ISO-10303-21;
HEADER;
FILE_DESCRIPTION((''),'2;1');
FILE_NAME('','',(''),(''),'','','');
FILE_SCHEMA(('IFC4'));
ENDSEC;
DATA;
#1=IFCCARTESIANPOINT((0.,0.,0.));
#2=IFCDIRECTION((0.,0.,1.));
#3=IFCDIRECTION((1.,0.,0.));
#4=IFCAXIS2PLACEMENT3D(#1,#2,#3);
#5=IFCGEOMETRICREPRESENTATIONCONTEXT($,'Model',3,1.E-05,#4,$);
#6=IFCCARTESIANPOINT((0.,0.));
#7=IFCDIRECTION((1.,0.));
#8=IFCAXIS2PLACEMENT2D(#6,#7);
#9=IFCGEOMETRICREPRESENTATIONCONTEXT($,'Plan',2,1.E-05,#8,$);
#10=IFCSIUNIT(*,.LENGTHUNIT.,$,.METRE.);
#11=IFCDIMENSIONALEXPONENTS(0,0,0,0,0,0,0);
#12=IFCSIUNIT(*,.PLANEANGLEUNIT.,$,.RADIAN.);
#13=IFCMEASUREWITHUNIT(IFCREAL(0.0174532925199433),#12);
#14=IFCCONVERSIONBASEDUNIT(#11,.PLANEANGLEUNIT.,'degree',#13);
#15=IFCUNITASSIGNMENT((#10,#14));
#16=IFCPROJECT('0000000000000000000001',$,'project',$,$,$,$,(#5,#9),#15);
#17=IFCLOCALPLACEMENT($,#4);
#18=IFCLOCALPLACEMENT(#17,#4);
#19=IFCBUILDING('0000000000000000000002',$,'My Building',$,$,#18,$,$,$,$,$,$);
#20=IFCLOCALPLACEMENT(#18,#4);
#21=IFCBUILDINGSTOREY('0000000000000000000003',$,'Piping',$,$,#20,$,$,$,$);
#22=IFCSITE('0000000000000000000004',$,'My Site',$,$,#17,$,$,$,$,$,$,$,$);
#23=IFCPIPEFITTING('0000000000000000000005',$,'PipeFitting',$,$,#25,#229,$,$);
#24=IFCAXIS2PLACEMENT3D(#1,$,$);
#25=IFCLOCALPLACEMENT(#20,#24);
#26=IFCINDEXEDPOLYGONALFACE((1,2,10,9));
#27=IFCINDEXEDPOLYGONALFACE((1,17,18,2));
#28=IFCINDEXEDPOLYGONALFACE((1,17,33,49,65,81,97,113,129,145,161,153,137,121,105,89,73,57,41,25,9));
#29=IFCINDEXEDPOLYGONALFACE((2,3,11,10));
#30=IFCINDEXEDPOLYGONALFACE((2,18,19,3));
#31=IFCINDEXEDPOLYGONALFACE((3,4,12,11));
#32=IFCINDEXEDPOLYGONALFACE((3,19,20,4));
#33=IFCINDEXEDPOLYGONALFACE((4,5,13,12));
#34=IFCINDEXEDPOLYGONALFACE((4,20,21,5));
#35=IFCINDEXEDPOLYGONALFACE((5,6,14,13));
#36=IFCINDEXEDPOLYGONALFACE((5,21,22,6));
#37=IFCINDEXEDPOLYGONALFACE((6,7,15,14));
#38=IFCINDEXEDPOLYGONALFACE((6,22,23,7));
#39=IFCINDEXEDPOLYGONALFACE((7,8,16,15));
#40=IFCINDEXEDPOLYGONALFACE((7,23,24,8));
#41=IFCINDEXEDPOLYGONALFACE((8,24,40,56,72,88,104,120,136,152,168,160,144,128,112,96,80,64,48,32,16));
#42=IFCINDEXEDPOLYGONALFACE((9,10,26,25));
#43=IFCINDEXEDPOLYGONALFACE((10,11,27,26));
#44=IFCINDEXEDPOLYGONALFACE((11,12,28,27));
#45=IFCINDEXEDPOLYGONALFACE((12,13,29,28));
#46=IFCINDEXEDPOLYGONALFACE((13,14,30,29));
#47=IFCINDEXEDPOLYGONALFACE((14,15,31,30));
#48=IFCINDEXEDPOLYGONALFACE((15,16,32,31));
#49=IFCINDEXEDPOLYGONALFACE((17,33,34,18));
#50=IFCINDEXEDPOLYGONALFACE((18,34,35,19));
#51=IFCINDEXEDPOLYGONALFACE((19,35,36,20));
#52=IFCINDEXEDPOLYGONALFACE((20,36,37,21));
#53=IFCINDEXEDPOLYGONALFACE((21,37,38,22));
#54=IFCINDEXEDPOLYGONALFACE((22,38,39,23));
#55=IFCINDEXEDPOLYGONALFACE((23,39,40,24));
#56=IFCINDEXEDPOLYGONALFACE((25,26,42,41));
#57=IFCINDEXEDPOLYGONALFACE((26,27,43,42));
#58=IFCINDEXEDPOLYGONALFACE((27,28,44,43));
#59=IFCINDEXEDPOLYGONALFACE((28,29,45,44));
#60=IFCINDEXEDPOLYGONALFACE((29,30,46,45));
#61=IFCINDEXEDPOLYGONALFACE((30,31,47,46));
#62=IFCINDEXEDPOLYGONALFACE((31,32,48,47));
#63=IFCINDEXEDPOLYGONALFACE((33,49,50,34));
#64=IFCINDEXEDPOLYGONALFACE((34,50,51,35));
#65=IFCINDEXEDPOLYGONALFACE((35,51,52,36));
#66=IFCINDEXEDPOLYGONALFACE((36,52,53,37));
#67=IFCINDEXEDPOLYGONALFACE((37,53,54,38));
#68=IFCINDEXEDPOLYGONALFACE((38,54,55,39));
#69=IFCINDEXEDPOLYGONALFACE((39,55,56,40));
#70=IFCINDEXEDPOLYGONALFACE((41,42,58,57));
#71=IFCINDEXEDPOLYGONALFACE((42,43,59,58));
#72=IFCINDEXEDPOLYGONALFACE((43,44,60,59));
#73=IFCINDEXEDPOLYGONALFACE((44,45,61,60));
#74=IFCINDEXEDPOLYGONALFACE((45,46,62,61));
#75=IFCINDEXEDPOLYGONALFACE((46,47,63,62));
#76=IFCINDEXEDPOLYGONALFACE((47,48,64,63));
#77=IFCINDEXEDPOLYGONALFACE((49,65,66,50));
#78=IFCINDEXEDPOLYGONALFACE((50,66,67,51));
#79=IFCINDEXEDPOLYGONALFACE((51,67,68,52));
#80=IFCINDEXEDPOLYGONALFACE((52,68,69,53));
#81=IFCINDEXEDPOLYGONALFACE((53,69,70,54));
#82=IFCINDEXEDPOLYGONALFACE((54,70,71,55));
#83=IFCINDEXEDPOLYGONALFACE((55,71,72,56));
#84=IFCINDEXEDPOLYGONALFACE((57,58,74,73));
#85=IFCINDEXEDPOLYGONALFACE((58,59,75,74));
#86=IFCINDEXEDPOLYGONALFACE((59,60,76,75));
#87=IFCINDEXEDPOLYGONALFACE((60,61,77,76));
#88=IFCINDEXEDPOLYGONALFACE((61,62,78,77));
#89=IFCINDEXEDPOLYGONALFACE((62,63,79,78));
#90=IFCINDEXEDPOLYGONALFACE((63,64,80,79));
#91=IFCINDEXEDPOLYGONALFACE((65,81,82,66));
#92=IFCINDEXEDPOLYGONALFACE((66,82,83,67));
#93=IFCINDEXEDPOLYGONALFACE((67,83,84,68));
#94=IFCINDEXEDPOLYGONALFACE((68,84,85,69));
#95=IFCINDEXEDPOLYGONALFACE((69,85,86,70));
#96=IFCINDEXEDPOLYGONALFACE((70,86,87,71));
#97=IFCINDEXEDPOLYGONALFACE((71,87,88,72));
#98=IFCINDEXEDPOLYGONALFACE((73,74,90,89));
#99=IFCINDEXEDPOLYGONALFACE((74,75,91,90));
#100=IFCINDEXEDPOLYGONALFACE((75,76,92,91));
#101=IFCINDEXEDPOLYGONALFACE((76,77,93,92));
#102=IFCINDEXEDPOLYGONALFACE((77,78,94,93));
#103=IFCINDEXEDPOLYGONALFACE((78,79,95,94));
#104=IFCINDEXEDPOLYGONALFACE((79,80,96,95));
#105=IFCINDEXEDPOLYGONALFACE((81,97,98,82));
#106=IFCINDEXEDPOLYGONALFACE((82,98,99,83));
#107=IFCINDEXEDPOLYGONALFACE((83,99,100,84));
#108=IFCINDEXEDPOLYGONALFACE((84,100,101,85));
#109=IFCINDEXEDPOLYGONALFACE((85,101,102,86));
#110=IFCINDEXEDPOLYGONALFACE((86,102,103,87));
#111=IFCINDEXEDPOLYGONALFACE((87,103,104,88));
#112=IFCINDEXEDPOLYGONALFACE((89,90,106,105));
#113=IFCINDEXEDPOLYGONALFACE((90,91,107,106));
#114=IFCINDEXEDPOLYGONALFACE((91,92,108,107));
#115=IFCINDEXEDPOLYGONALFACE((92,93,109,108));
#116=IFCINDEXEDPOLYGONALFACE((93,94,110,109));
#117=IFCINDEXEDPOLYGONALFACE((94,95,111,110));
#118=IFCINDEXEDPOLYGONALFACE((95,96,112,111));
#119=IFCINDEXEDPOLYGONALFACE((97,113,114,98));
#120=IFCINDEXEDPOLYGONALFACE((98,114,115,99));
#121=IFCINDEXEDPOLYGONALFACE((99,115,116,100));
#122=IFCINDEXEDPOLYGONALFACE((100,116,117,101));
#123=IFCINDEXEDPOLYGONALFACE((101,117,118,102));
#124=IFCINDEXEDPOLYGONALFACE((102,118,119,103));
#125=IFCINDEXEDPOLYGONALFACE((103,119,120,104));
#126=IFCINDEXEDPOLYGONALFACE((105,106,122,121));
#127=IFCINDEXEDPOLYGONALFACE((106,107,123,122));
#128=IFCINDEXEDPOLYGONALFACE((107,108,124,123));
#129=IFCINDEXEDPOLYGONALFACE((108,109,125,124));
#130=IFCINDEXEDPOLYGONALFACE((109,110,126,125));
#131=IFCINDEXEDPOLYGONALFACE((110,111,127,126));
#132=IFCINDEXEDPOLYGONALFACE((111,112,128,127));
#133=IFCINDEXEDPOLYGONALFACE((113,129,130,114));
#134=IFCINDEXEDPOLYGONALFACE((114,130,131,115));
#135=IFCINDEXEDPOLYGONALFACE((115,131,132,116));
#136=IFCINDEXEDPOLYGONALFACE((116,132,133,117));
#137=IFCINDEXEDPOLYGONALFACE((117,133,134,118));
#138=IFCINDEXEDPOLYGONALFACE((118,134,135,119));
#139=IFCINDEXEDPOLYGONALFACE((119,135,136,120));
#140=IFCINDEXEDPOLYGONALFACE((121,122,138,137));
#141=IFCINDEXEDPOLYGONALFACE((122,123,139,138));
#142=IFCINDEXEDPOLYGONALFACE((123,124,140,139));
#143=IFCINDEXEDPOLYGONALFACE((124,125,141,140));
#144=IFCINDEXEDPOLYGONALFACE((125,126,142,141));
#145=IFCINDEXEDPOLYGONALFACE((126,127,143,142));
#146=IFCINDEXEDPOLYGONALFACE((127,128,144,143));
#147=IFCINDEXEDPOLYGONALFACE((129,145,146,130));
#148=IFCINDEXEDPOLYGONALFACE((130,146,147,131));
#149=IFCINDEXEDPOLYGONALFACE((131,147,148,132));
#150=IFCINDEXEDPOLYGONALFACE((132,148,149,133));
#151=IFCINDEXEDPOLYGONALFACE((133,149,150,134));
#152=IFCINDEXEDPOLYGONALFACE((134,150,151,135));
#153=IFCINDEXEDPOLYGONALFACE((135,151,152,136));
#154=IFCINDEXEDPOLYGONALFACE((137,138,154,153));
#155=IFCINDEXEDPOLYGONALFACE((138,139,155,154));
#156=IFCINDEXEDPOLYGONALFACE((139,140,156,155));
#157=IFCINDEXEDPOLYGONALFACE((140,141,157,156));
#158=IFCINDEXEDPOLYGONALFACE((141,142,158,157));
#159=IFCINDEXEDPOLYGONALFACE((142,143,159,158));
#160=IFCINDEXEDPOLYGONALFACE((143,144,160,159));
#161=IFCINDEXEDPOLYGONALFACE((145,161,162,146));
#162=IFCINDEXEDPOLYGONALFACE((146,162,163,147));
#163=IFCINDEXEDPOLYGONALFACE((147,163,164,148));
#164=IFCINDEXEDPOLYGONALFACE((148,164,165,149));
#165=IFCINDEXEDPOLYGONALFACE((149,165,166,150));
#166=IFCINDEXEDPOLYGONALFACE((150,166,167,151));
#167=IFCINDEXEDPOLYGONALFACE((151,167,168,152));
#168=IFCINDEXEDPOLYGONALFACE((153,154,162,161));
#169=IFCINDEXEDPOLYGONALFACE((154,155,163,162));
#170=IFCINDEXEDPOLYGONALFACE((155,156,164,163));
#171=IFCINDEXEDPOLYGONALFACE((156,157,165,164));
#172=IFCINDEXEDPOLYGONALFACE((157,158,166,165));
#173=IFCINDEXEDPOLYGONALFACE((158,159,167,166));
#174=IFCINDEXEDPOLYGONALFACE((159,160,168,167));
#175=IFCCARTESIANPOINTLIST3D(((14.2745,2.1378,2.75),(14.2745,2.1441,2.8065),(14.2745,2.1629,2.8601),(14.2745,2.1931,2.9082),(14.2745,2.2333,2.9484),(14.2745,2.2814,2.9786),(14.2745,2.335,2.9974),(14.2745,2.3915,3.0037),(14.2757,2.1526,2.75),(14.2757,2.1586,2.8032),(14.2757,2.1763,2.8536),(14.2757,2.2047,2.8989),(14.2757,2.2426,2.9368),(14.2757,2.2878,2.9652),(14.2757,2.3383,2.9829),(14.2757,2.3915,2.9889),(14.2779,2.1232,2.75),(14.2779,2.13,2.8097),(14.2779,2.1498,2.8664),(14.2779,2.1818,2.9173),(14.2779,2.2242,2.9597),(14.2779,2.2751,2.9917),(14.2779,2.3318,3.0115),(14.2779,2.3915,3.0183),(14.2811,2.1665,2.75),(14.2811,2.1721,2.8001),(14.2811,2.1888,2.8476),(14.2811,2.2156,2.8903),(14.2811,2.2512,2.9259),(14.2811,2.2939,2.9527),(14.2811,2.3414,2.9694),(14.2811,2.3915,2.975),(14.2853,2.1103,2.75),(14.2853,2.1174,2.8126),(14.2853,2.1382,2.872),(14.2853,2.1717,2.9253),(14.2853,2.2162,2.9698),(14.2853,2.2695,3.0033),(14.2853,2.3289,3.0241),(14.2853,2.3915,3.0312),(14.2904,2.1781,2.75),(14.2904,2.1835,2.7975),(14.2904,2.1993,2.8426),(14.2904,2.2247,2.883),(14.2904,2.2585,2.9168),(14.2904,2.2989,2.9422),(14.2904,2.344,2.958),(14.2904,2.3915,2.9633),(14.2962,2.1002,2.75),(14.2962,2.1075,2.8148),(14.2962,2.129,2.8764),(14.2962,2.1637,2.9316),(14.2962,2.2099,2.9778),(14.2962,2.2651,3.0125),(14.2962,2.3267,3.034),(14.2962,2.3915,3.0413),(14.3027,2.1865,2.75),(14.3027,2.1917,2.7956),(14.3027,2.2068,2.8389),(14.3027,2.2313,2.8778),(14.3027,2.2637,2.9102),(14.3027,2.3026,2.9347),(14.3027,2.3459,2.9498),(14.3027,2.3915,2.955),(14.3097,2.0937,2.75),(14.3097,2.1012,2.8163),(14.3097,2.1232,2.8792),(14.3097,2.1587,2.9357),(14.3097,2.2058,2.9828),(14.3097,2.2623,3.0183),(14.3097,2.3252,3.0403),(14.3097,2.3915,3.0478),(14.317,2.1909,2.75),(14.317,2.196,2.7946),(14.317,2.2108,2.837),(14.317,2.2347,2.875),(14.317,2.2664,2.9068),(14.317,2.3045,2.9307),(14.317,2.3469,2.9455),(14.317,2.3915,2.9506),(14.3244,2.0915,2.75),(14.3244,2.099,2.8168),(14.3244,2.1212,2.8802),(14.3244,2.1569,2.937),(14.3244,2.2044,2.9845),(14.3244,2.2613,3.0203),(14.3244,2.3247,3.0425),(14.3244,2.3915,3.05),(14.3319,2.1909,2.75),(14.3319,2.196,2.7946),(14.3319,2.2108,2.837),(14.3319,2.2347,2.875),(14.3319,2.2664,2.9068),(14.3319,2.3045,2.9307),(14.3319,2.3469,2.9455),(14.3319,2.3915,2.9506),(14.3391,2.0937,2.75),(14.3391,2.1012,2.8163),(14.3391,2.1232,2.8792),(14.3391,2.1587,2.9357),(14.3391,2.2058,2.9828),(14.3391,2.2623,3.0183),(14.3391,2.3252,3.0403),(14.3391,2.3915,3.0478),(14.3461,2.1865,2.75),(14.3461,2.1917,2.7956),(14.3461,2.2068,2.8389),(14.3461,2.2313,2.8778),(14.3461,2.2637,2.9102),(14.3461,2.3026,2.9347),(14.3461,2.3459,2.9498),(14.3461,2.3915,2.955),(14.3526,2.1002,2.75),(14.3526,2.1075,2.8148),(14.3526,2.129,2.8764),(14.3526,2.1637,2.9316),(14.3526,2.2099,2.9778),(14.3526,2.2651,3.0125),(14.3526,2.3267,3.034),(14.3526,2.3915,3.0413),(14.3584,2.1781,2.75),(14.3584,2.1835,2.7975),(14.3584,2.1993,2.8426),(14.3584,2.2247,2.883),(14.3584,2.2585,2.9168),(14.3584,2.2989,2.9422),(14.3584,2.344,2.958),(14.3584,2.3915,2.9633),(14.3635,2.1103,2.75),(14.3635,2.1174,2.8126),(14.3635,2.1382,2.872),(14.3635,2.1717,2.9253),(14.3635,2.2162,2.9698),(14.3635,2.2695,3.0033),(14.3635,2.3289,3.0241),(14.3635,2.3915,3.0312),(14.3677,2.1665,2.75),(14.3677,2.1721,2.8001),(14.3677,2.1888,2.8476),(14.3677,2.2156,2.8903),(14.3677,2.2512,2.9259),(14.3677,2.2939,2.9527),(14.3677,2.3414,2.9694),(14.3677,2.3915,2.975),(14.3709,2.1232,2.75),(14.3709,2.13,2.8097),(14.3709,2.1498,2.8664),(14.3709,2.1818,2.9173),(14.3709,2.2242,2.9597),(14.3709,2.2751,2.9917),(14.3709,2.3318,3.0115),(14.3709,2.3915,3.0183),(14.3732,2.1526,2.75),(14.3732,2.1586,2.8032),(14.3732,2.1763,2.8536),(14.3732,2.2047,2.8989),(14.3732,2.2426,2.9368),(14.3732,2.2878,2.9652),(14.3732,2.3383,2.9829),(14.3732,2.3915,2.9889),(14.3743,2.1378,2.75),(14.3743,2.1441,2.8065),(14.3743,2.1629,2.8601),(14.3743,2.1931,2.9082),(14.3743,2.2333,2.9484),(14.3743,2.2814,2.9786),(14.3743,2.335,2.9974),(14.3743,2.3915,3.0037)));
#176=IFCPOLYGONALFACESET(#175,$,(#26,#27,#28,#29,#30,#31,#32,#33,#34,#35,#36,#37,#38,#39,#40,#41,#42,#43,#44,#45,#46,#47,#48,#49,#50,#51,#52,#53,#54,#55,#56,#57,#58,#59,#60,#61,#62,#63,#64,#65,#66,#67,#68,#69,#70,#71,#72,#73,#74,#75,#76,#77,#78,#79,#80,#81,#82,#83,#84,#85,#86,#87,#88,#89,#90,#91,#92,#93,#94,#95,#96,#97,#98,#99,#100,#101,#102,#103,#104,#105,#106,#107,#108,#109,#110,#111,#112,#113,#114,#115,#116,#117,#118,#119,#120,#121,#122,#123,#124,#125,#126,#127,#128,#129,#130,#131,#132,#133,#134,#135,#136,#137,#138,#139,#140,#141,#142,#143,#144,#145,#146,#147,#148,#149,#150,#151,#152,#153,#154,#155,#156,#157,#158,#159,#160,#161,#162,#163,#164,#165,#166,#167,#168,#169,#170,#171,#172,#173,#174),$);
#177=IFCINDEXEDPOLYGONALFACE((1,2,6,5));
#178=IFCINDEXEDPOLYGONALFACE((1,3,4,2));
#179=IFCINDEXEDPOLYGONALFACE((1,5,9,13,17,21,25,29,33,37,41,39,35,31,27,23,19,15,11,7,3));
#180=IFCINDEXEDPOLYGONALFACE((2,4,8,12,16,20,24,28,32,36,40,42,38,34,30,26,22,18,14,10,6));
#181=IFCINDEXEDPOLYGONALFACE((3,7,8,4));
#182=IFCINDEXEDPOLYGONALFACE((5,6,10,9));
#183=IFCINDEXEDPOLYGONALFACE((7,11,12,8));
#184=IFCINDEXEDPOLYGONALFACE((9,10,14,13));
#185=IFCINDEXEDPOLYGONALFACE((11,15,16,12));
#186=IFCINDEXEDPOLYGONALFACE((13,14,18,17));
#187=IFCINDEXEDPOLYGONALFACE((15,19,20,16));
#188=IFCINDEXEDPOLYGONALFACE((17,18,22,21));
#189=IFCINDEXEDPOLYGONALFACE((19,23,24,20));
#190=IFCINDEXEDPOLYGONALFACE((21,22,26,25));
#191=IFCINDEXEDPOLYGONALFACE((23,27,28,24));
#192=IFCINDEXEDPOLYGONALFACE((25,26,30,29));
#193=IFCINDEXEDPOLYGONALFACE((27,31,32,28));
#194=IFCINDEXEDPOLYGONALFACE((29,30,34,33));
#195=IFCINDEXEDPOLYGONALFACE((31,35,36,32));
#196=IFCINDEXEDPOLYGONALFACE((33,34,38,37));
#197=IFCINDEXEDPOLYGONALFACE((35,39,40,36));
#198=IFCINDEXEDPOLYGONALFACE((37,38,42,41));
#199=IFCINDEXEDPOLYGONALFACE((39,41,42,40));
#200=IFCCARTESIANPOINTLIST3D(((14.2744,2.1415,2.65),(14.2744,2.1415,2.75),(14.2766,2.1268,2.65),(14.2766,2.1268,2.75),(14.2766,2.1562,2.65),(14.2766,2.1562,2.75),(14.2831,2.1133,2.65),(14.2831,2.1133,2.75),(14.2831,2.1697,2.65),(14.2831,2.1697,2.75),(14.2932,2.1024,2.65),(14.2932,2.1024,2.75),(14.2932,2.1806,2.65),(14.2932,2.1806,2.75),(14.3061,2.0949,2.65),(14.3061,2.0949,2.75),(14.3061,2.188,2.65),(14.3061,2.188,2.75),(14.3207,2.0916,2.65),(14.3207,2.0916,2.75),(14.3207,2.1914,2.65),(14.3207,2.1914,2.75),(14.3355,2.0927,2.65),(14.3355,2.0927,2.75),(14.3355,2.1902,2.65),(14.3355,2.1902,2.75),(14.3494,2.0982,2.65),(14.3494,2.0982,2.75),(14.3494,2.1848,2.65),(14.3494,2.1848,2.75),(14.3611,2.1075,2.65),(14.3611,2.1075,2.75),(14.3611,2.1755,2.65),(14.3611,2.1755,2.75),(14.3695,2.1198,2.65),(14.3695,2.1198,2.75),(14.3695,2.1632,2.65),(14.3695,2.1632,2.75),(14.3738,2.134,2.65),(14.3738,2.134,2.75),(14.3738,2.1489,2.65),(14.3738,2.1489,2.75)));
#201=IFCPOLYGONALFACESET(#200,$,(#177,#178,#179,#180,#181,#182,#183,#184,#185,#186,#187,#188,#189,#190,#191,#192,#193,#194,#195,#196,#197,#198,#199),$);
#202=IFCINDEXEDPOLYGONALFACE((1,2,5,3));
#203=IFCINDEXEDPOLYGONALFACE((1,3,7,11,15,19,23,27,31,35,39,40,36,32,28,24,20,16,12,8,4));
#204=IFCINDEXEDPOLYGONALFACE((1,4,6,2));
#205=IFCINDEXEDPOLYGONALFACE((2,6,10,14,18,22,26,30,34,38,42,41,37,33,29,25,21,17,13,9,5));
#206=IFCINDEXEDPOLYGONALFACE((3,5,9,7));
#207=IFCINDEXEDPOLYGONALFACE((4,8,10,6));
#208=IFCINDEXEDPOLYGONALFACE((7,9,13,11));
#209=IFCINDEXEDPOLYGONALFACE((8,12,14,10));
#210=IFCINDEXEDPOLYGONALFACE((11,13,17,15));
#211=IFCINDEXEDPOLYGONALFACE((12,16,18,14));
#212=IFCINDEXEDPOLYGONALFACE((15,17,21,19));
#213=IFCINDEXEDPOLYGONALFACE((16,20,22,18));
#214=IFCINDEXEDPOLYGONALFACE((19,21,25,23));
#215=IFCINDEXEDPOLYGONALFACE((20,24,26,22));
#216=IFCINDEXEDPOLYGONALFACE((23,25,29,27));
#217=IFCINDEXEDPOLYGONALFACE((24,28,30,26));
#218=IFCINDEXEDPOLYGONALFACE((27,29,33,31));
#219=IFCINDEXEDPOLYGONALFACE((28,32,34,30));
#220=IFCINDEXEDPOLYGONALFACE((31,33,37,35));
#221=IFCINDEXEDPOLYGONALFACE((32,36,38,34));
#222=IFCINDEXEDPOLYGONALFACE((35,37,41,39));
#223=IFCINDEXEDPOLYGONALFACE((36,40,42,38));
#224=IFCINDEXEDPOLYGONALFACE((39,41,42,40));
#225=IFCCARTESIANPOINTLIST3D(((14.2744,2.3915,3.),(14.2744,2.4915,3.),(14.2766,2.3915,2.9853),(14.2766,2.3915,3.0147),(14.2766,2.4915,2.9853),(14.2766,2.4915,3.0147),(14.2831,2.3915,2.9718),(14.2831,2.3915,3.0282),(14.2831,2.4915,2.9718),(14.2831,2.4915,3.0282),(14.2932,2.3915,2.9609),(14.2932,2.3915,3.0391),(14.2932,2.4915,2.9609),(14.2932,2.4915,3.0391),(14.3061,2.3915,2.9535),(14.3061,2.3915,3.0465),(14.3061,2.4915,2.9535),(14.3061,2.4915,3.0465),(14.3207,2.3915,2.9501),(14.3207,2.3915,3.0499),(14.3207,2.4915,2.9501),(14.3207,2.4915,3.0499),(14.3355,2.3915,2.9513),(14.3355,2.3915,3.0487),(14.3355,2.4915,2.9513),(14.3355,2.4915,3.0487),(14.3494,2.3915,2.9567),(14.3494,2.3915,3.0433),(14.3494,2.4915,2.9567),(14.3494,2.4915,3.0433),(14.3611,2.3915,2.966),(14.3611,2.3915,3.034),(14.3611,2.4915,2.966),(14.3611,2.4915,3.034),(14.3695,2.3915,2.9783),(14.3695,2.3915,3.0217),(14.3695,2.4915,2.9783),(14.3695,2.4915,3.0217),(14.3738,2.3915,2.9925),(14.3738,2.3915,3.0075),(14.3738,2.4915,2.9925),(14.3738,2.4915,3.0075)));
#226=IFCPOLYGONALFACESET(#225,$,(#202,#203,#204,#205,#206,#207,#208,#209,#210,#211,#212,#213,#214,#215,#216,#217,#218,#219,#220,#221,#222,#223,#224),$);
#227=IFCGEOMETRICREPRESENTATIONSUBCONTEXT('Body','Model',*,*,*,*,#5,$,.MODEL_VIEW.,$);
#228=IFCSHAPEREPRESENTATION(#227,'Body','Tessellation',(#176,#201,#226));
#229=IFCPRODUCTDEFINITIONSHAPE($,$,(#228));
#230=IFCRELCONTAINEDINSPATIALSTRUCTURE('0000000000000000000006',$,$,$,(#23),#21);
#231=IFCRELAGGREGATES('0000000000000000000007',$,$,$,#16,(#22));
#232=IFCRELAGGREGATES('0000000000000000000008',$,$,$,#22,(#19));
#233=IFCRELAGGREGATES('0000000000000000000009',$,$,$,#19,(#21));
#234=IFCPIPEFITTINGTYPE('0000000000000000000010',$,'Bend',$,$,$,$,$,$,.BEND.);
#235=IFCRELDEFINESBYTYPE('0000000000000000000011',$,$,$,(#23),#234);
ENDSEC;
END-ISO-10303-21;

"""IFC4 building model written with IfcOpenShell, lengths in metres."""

from ifc_helpers import new_model, entity, si_unit, converted_unit, frame, origin_with_axes, origin_2d_with_axis, place, context, subcontext, project, spatial, circle, extrude, source, transform, mapped, type_object, type_shapes, element, save


model = new_model("IFC4")

# Units and contexts
model_context = context("Model", 3, precision=1e-05, world=origin_with_axes())
plan_context = context("Plan", 2, precision=1e-05, world=origin_2d_with_axis())
body_context = subcontext(model_context, "Body", "Model", "MODEL_VIEW")
ifc_project = project(units=[si_unit("LENGTHUNIT", "METRE"), converted_unit("PLANEANGLEUNIT", "degree", entity("IfcReal", 0.0174532925199433), si_unit("PLANEANGLEUNIT", "RADIAN"), dimensions=[0, 0, 0, 0, 0, 0, 0])], contexts=[model_context, plan_context])

# Site, building, storey
site_placement = place(None, origin_with_axes())
site = spatial("IfcSite", under=ifc_project, at=site_placement, Name="My Site")
building_placement = place(site_placement, origin_with_axes())
building = spatial("IfcBuilding", under=site, at=building_placement, Name="My Building")
storey_placement = place(building_placement, origin_with_axes())
storey = spatial("IfcBuildingStorey", under=building, at=storey_placement, Name="Piping")

# Pipe fitting
pipe_fitting_type_1 = type_object("IfcPipeFittingType", Name="Bend", PredefinedType="BEND")
shared_shape = source(origin_with_axes(), body_context, "Body", "SolidModel", [
    entity("IfcSweptDiskSolid", entity("IfcIndexedPolyCurve", entity("IfcCartesianPointList3D", [[0.0, 0.0, -0.1], [0.0, 0.0732, -0.2768], [0.0, 0.25, -0.35]]), [entity("IfcArcIndex", [1, 2, 3])]), 0.05),
    extrude(circle(Radius=0.05), origin_with_axes(), (0.0, 0.0, -1.0), 0.1),
    extrude(circle(Radius=0.05), frame((0.0, 0.25, -0.35), z_axis=(0.0, 1.0, 0.0), x_axis=(1.0, 0.0, 0.0)), (0.0, 0.0, 1.0), 0.1),
])
type_shapes(pipe_fitting_type_1, [shared_shape])
for number, where, z_axis, x_axis, name in (
    (1, (14.3244, 2.1415, 2.65), (0.0, 0.0, -1.0), (-1.0, 0.0, 0.0), "PipeFitting"),
):
    element("IfcPipeFitting", number, at=place(storey_placement, frame(where, z_axis=z_axis, x_axis=x_axis)), inside=storey, type_object=pipe_fitting_type_1, Name=name, context=body_context, shape_type="MappedRepresentation", body=[
        mapped(shared_shape, transform((0.0, 0.0, 0.0), x_axis=(1.0, 0.0, 0.0), y_axis=(0.0, 1.0, 0.0), z_axis=(0.0, 0.0, 1.0), scale=1.0)),
    ])

save(model, "model.ifc")
